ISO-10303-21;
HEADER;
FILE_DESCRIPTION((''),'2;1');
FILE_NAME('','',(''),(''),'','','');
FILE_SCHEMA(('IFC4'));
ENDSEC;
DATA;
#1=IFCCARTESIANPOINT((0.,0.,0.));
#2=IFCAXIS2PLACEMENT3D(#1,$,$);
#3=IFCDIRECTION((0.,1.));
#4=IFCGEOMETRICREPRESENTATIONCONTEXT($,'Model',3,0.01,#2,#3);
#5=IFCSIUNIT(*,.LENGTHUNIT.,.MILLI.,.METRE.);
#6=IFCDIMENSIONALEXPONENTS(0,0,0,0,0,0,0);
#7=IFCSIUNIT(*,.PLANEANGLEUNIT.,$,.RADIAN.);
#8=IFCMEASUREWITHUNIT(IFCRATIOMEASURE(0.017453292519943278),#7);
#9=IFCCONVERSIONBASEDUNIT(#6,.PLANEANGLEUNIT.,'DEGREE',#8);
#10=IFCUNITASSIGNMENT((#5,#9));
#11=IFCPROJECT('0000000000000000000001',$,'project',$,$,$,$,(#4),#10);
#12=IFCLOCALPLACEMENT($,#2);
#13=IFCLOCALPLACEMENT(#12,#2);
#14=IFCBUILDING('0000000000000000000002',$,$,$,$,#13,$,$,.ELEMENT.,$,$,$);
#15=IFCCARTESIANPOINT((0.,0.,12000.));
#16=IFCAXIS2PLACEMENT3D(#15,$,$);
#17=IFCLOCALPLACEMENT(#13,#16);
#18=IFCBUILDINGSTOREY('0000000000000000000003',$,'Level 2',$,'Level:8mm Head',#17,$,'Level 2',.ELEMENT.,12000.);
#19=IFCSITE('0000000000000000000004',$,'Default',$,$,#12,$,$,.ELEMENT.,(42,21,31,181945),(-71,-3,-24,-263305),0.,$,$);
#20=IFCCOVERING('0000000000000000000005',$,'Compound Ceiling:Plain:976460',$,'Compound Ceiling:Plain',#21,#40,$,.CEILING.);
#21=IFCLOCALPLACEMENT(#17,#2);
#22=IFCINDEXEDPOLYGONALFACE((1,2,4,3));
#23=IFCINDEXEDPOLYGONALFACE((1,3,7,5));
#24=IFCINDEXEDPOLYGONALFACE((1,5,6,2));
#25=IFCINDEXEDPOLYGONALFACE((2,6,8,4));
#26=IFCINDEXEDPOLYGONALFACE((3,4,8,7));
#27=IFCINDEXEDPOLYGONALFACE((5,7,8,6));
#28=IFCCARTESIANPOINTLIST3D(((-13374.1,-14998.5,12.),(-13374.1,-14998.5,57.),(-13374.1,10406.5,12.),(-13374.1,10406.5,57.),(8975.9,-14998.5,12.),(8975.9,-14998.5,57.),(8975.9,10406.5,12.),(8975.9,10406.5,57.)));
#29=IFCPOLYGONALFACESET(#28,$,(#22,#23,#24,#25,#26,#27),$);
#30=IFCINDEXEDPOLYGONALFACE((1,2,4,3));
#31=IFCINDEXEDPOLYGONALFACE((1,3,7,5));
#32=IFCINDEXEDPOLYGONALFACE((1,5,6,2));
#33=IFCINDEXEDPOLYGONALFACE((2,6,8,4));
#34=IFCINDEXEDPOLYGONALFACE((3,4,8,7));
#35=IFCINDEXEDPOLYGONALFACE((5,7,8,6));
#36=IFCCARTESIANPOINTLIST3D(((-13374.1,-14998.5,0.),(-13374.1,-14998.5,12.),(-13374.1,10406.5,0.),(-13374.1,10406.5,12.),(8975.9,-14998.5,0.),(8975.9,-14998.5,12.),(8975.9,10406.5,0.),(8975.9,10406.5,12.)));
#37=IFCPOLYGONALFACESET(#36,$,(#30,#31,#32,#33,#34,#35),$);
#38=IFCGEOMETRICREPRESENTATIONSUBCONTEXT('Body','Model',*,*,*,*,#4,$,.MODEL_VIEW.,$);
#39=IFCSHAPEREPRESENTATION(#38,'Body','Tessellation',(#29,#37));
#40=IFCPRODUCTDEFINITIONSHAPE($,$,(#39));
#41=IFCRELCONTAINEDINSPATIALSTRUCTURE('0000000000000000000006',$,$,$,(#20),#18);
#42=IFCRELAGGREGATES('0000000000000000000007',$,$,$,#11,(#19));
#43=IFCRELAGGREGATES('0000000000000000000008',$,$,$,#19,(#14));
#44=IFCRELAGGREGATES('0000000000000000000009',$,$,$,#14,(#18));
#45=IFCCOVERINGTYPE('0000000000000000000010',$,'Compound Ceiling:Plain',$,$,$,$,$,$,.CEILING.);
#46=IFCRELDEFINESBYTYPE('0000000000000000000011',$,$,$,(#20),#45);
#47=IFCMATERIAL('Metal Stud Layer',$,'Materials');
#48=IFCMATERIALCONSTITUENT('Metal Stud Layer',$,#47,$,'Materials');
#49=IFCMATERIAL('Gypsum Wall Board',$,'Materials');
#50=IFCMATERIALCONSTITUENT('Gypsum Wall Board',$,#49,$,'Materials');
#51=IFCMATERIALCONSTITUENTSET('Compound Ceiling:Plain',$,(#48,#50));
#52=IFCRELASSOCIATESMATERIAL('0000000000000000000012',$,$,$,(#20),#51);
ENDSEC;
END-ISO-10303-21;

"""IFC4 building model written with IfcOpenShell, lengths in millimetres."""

from ifc_helpers import new_model, entity, si_unit, converted_unit, direction, frame, origin, place, context, subcontext, project, spatial, indexed_curve, outline, extrude, material, constituent, constituent_set, type_object, element, save


model = new_model("IFC4")

# Units and contexts
model_context = context("Model", 3, precision=0.01, world=origin(), true_north=direction((0.0, 1.0)))
body_context = subcontext(model_context, "Body", "Model", "MODEL_VIEW")
ifc_project = project(units=[si_unit("LENGTHUNIT", "METRE", prefix="MILLI"), converted_unit("PLANEANGLEUNIT", "DEGREE", entity("IfcRatioMeasure", 0.017453292519943278), si_unit("PLANEANGLEUNIT", "RADIAN"), dimensions=[0, 0, 0, 0, 0, 0, 0])], contexts=[model_context])

# Site, building, storey
site_placement = place(None, origin())
site = spatial("IfcSite", under=ifc_project, at=site_placement, Name="Default", CompositionType="ELEMENT", RefLatitude=(42, 21, 31, 181945), RefLongitude=(-71, -3, -24, -263305), RefElevation=0.0)
building_placement = place(site_placement, origin())
building = spatial("IfcBuilding", under=site, at=building_placement, CompositionType="ELEMENT")
storey_placement = place(building_placement, frame((0.0, 0.0, 12000.0)))
storey = spatial("IfcBuildingStorey", under=building, at=storey_placement, Name="Level 2", ObjectType="Level:8mm Head", LongName="Level 2", CompositionType="ELEMENT", Elevation=12000.0)

# Covering
ifc_material_1 = material(Name="Metal Stud Layer", Category="Materials")
ifc_constituent_1 = constituent(ifc_material_1, Name="Metal Stud Layer", Category="Materials")
ifc_material_2 = material(Name="Gypsum Wall Board", Category="Materials")
ifc_constituent_2 = constituent(ifc_material_2, Name="Gypsum Wall Board", Category="Materials")
ifc_constituent_set = constituent_set(constituents=[ifc_constituent_1, ifc_constituent_2], Name="Compound Ceiling:Plain")
covering_type = type_object("IfcCoveringType", Name="Compound Ceiling:Plain", PredefinedType="CEILING")
covering_placement = place(storey_placement, frame((-13374.1, -14998.5, 0.0)))
element("IfcCovering", 1, at=covering_placement, inside=storey, type_object=covering_type, material=ifc_constituent_set, Name="Compound Ceiling:Plain:976460", ObjectType="Compound Ceiling:Plain", PredefinedType="CEILING", context=body_context, shape_type="SweptSolid", body=[
    extrude(outline(indexed_curve([(-12702.5, -11175.0), (12702.5, -11175.0), (12702.5, 11175.0), (-12702.5, 11175.0), (-12702.5, -11175.0)], self_intersect=False)), frame((11175.0, 12702.5, 12.0), z_axis=(0.0, 0.0, 1.0), x_axis=(0.0, -1.0, 0.0)), (0.0, 0.0, 1.0), 45.0),
    extrude(outline(indexed_curve([(-11175.0, -12702.5), (11175.0, -12702.5), (11175.0, 12702.5), (-11175.0, 12702.5), (-11175.0, -12702.5)], self_intersect=False)), frame((11175.0, 12702.5, 0.0), z_axis=(0.0, 0.0, 1.0), x_axis=(-1.0, 0.0, 0.0)), (0.0, 0.0, 1.0), 12.0),
])

save(model, "model.ifc")
